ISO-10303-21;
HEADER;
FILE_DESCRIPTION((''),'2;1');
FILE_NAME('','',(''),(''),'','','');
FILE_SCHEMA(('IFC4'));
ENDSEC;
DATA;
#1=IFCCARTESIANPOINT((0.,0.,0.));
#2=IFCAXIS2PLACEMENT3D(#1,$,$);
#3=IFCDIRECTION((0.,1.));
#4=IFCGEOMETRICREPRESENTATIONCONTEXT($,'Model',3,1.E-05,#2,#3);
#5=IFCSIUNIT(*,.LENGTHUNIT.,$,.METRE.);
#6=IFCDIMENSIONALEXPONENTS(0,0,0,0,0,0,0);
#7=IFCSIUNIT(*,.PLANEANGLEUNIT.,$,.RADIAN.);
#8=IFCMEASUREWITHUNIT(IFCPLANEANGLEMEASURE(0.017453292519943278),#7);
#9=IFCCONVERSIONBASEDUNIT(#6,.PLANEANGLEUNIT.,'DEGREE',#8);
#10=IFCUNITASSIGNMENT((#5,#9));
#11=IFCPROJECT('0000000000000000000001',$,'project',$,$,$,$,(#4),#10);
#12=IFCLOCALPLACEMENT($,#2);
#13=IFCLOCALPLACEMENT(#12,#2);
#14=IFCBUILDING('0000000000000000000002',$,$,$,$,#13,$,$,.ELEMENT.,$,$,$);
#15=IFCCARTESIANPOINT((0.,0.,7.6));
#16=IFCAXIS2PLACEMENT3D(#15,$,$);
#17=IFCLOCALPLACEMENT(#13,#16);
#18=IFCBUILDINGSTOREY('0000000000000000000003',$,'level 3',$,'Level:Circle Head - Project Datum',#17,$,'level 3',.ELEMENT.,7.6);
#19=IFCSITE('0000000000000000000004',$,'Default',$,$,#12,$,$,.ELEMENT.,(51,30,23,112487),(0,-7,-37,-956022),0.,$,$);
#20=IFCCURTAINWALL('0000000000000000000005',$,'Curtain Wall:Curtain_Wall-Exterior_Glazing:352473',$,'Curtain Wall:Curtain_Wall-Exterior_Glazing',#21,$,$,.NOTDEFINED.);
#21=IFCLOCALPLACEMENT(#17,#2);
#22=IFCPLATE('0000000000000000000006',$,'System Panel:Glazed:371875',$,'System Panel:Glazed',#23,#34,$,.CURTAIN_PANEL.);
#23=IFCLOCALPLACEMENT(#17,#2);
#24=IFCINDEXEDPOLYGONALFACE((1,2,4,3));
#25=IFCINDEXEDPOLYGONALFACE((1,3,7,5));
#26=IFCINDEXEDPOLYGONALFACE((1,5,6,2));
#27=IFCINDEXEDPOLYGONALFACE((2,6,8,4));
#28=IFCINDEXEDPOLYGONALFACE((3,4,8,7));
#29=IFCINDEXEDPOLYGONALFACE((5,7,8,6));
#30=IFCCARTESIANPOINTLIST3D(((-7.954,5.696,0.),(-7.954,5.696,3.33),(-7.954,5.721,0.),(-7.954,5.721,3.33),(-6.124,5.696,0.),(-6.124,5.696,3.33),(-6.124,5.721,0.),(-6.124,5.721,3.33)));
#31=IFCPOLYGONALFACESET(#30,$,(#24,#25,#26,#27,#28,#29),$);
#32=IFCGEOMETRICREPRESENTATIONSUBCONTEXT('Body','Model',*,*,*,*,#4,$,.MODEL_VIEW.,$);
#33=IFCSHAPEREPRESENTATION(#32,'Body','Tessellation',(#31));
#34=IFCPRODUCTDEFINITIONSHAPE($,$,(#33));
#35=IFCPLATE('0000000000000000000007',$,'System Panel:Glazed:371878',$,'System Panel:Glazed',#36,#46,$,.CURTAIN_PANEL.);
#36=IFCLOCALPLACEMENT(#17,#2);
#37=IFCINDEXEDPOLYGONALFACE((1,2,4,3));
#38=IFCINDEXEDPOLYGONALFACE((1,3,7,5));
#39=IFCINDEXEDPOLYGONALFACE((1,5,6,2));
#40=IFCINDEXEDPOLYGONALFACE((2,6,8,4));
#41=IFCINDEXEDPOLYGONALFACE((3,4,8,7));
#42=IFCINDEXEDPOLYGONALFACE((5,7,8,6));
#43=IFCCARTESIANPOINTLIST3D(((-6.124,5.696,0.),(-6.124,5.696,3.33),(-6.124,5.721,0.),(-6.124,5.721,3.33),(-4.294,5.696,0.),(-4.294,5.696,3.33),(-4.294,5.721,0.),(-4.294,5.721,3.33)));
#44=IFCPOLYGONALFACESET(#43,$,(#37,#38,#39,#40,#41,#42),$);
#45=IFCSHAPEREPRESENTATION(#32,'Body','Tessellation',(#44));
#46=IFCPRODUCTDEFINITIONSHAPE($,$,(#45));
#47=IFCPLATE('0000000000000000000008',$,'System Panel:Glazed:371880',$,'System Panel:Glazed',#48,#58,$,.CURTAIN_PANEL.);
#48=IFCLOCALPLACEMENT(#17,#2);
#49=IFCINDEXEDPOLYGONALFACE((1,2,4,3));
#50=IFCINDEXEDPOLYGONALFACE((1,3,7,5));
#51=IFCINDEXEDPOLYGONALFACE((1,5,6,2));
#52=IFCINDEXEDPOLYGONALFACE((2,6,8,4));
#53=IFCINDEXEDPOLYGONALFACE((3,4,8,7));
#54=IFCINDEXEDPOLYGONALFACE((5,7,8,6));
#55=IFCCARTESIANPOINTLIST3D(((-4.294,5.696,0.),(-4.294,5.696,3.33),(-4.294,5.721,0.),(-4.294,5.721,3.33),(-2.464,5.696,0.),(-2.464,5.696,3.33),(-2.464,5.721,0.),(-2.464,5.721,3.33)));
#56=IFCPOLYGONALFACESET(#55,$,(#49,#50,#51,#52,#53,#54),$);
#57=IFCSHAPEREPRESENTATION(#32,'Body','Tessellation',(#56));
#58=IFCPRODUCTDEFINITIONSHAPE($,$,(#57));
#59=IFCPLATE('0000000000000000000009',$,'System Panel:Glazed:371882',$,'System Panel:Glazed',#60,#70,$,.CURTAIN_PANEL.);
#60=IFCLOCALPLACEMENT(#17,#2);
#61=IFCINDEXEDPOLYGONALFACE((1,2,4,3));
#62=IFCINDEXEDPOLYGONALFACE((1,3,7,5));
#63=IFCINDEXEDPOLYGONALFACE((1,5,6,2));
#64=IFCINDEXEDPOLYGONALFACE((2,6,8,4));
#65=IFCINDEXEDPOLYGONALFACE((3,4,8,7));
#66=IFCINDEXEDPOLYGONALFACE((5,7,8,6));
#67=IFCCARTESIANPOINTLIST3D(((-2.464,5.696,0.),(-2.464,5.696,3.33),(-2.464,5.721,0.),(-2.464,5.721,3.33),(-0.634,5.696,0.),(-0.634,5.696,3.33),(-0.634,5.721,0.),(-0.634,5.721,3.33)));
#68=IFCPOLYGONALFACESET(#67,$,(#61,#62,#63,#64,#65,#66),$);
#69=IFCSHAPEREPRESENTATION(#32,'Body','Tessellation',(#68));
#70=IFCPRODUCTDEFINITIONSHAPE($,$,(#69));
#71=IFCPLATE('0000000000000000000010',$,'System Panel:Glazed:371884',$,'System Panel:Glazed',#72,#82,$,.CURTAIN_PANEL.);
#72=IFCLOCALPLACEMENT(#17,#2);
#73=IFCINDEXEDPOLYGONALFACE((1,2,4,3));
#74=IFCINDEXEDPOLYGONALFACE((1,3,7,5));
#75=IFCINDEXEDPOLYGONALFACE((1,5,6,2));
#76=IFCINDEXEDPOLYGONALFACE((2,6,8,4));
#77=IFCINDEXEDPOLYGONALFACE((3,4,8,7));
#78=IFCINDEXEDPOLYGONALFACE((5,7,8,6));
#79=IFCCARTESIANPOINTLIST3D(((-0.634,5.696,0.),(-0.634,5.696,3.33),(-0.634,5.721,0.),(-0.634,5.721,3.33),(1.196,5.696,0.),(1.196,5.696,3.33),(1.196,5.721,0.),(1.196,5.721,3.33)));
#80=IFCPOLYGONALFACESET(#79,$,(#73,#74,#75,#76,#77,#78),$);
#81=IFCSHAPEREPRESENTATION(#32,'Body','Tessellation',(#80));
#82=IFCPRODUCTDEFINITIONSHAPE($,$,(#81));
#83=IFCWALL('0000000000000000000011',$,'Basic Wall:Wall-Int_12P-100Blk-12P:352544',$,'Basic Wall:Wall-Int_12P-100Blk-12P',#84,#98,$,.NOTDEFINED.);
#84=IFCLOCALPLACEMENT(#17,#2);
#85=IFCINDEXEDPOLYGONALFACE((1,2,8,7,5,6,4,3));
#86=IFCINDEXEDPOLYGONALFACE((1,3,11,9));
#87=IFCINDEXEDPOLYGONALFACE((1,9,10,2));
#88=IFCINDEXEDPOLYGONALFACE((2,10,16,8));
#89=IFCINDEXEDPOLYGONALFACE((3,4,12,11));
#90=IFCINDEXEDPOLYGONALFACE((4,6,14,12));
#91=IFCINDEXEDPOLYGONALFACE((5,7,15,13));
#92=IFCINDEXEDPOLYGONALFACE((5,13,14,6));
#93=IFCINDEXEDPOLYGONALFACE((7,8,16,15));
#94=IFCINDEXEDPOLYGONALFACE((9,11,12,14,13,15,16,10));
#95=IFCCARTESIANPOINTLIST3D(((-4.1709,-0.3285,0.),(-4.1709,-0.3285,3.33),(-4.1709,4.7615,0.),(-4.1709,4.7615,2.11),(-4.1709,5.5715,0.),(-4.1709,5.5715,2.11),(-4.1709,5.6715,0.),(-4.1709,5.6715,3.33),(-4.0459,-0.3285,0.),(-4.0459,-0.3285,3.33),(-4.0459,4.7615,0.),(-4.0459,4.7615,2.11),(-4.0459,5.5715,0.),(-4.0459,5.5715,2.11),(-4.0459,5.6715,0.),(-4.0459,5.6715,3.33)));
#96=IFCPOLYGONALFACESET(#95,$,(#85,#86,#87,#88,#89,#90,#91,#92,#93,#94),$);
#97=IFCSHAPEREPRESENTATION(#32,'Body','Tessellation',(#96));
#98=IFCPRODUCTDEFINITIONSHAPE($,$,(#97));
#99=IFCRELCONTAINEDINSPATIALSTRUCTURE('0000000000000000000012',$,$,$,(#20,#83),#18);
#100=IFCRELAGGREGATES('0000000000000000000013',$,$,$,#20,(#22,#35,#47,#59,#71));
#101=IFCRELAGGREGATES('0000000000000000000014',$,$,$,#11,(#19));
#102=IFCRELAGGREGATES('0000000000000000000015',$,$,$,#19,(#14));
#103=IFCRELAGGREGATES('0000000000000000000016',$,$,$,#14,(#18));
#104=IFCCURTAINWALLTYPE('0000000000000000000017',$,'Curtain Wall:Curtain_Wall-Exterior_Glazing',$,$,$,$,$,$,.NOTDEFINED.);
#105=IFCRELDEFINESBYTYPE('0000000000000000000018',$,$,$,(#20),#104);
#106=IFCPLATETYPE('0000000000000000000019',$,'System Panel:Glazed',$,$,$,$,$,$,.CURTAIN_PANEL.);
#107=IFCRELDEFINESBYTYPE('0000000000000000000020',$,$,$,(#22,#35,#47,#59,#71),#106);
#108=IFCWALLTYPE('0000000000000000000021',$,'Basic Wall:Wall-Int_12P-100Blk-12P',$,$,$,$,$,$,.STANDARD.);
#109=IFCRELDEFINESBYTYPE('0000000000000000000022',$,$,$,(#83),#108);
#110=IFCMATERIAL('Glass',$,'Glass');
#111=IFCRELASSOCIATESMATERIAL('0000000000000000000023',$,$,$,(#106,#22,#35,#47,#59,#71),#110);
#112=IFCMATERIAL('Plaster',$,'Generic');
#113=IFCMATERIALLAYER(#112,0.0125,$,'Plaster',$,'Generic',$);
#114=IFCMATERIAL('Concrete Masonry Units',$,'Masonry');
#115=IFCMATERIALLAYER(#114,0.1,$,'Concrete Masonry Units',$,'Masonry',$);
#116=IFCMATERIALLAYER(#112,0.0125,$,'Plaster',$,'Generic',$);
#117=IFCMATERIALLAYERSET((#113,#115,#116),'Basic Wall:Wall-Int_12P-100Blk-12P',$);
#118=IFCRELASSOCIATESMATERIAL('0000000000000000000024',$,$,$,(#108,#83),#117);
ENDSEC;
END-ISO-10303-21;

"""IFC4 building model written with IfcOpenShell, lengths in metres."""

from ifc_helpers import new_model, entity, si_unit, converted_unit, direction, frame, frame_2d, origin, origin_2d_with_axis, place, context, subcontext, project, spatial, polyline, rectangle, extrude, clip, bounded_halfspace, source, transform, mapped, material, layer, layer_set, layer_usage, type_object, type_shapes, element, aggregate, save


model = new_model("IFC4")

# Units and contexts
model_context = context("Model", 3, precision=1e-05, world=origin(), true_north=direction((0.0, 1.0)))
body_context = subcontext(model_context, "Body", "Model", "MODEL_VIEW")
ifc_project = project(units=[si_unit("LENGTHUNIT", "METRE"), converted_unit("PLANEANGLEUNIT", "DEGREE", entity("IfcPlaneAngleMeasure", 0.017453292519943278), si_unit("PLANEANGLEUNIT", "RADIAN"), dimensions=[0, 0, 0, 0, 0, 0, 0])], contexts=[model_context])

# Site, building, storey
site_placement = place(None, origin())
site = spatial("IfcSite", under=ifc_project, at=site_placement, Name="Default", CompositionType="ELEMENT", RefLatitude=(51, 30, 23, 112487), RefLongitude=(0, -7, -37, -956022), RefElevation=0.0)
building_placement = place(site_placement, origin())
building = spatial("IfcBuilding", under=site, at=building_placement, CompositionType="ELEMENT")
storey_placement = place(building_placement, frame((0.0, 0.0, 7.6)))
storey = spatial("IfcBuildingStorey", under=building, at=storey_placement, Name="level 3", ObjectType="Level:Circle Head - Project Datum", LongName="level 3", CompositionType="ELEMENT", Elevation=7.6)

# Curtain wall, plates
curtain_wall_type = type_object("IfcCurtainWallType", Name="Curtain Wall:Curtain_Wall-Exterior_Glazing", PredefinedType="NOTDEFINED")
curtain_wall_placement = place(storey_placement, frame((0.0, 0.0, -7.6)))
curtain_wall = element("IfcCurtainWall", 1, at=curtain_wall_placement, inside=storey, type_object=curtain_wall_type, Name="Curtain Wall:Curtain_Wall-Exterior_Glazing:352473", ObjectType="Curtain Wall:Curtain_Wall-Exterior_Glazing", PredefinedType="NOTDEFINED")
ifc_material_1 = material(Name="Glass", Category="Glass")
plate_type = type_object("IfcPlateType", Name="System Panel:Glazed", PredefinedType="CURTAIN_PANEL", material=ifc_material_1)
shared_shape_1 = source(origin(), body_context, "Body", "SweptSolid", [
    extrude(rectangle(XDim=0.025, YDim=1.83, at=origin_2d_with_axis()), frame((0.915, 0.0125, 0.0), z_axis=(0.0, 0.0, 1.0), x_axis=(0.0, 1.0, 0.0)), (0.0, 0.0, 1.0), 3.33),
])
type_shapes(plate_type, [shared_shape_1])
plate_1_placement = place(curtain_wall_placement, frame((-7.954, 5.696, 7.6)))
plate_1 = element("IfcPlate", 2, at=plate_1_placement, type_object=plate_type, material=ifc_material_1, Name="System Panel:Glazed:371875", ObjectType="System Panel:Glazed", PredefinedType="CURTAIN_PANEL", context=body_context, shape_type="MappedRepresentation", body=[
    mapped(shared_shape_1, transform((0.0, 0.0, 0.0), scale=1.0)),
])
plate_2_placement = place(curtain_wall_placement, frame((-6.124, 5.696, 7.6)))
plate_2 = element("IfcPlate", 3, at=plate_2_placement, type_object=plate_type, material=ifc_material_1, Name="System Panel:Glazed:371878", ObjectType="System Panel:Glazed", PredefinedType="CURTAIN_PANEL", context=body_context, shape_type="MappedRepresentation", body=[
    mapped(shared_shape_1, transform((0.0, 0.0, 0.0), scale=1.0)),
])
plate_3_placement = place(curtain_wall_placement, frame((-4.294, 5.696, 7.6)))
plate_3 = element("IfcPlate", 4, at=plate_3_placement, type_object=plate_type, material=ifc_material_1, Name="System Panel:Glazed:371880", ObjectType="System Panel:Glazed", PredefinedType="CURTAIN_PANEL", context=body_context, shape_type="MappedRepresentation", body=[
    mapped(shared_shape_1, transform((0.0, 0.0, 0.0), scale=1.0)),
])
plate_4_placement = place(curtain_wall_placement, frame((-2.464, 5.696, 7.6)))
plate_4 = element("IfcPlate", 5, at=plate_4_placement, type_object=plate_type, material=ifc_material_1, Name="System Panel:Glazed:371882", ObjectType="System Panel:Glazed", PredefinedType="CURTAIN_PANEL", context=body_context, shape_type="MappedRepresentation", body=[
    mapped(shared_shape_1, transform((0.0, 0.0, 0.0), scale=1.0)),
])
plate_5_placement = place(curtain_wall_placement, frame((-0.634, 5.696, 7.6)))
plate_5 = element("IfcPlate", 6, at=plate_5_placement, type_object=plate_type, material=ifc_material_1, Name="System Panel:Glazed:371884", ObjectType="System Panel:Glazed", PredefinedType="CURTAIN_PANEL", context=body_context, shape_type="MappedRepresentation", body=[
    mapped(shared_shape_1, transform((0.0, 0.0, 0.0), scale=1.0)),
])
aggregate(curtain_wall, [plate_1, plate_2, plate_3, plate_4, plate_5])

# Wall, opening
ifc_material_2 = material(Name="Plaster", Category="Generic")
ifc_layer_1 = layer(ifc_material_2, 0.0125, Name="Plaster", Category="Generic")
ifc_material_3 = material(Name="Concrete Masonry Units", Category="Masonry")
ifc_layer_2 = layer(ifc_material_3, 0.1, Name="Concrete Masonry Units", Category="Masonry")
ifc_layer_3 = layer(ifc_material_2, 0.0125, Name="Plaster", Category="Generic")
ifc_layer_set_1 = layer_set([ifc_layer_1, ifc_layer_2, ifc_layer_3], Name="Basic Wall:Wall-Int_12P-100Blk-12P")
ifc_layer_usage_1 = layer_usage(ifc_layer_set_1, "AXIS2", "NEGATIVE", 0.0625)
wall_type = type_object("IfcWallType", Name="Basic Wall:Wall-Int_12P-100Blk-12P", PredefinedType="STANDARD", material=ifc_layer_set_1)
wall_placement = place(storey_placement, frame((-4.1084, 5.6715, 0.0), z_axis=(0.0, 0.0, 1.0), x_axis=(0.0, -1.0, 0.0)))
wall = element("IfcWall", 7, at=wall_placement, inside=storey, type_object=wall_type, material=ifc_layer_usage_1, Name="Basic Wall:Wall-Int_12P-100Blk-12P:352544", ObjectType="Basic Wall:Wall-Int_12P-100Blk-12P", PredefinedType="NOTDEFINED", context=body_context, shape_type="Clipping", body=[
    clip(extrude(rectangle(XDim=6.0, YDim=0.125, at=frame_2d((3.0, 0.0), x_axis=(1.0, 0.0))), origin(), (0.0, 0.0, 1.0), 3.33), bounded_halfspace(frame((0.0, -0.0625, 3.33), z_axis=(0.0, 0.0, -1.0), x_axis=(-1.0, 0.0, 0.0)), True, frame((0.0, -0.0625, 3.33)), polyline([(0.0, 0.0), (6.0, 0.0), (6.0, 0.125), (0.0, 0.125), (0.0, 0.0)]))),
])
opening_1_placement = place(wall_placement, frame((0.1, -0.0625, 0.0)))
element("IfcOpeningElement", 8, at=opening_1_placement, cuts=wall, PredefinedType="OPENING", context=body_context, shape_type="SweptSolid", body=[
    extrude(rectangle(XDim=2.11, YDim=0.81, at=frame_2d((1.055, 0.405), x_axis=(1.0, 0.0))), frame((0.0, 0.0, 0.0), z_axis=(0.0, 1.0, 0.0), x_axis=(0.0, 0.0, 1.0)), (0.0, 0.0, 1.0), 0.125),
])

save(model, "model.ifc")
